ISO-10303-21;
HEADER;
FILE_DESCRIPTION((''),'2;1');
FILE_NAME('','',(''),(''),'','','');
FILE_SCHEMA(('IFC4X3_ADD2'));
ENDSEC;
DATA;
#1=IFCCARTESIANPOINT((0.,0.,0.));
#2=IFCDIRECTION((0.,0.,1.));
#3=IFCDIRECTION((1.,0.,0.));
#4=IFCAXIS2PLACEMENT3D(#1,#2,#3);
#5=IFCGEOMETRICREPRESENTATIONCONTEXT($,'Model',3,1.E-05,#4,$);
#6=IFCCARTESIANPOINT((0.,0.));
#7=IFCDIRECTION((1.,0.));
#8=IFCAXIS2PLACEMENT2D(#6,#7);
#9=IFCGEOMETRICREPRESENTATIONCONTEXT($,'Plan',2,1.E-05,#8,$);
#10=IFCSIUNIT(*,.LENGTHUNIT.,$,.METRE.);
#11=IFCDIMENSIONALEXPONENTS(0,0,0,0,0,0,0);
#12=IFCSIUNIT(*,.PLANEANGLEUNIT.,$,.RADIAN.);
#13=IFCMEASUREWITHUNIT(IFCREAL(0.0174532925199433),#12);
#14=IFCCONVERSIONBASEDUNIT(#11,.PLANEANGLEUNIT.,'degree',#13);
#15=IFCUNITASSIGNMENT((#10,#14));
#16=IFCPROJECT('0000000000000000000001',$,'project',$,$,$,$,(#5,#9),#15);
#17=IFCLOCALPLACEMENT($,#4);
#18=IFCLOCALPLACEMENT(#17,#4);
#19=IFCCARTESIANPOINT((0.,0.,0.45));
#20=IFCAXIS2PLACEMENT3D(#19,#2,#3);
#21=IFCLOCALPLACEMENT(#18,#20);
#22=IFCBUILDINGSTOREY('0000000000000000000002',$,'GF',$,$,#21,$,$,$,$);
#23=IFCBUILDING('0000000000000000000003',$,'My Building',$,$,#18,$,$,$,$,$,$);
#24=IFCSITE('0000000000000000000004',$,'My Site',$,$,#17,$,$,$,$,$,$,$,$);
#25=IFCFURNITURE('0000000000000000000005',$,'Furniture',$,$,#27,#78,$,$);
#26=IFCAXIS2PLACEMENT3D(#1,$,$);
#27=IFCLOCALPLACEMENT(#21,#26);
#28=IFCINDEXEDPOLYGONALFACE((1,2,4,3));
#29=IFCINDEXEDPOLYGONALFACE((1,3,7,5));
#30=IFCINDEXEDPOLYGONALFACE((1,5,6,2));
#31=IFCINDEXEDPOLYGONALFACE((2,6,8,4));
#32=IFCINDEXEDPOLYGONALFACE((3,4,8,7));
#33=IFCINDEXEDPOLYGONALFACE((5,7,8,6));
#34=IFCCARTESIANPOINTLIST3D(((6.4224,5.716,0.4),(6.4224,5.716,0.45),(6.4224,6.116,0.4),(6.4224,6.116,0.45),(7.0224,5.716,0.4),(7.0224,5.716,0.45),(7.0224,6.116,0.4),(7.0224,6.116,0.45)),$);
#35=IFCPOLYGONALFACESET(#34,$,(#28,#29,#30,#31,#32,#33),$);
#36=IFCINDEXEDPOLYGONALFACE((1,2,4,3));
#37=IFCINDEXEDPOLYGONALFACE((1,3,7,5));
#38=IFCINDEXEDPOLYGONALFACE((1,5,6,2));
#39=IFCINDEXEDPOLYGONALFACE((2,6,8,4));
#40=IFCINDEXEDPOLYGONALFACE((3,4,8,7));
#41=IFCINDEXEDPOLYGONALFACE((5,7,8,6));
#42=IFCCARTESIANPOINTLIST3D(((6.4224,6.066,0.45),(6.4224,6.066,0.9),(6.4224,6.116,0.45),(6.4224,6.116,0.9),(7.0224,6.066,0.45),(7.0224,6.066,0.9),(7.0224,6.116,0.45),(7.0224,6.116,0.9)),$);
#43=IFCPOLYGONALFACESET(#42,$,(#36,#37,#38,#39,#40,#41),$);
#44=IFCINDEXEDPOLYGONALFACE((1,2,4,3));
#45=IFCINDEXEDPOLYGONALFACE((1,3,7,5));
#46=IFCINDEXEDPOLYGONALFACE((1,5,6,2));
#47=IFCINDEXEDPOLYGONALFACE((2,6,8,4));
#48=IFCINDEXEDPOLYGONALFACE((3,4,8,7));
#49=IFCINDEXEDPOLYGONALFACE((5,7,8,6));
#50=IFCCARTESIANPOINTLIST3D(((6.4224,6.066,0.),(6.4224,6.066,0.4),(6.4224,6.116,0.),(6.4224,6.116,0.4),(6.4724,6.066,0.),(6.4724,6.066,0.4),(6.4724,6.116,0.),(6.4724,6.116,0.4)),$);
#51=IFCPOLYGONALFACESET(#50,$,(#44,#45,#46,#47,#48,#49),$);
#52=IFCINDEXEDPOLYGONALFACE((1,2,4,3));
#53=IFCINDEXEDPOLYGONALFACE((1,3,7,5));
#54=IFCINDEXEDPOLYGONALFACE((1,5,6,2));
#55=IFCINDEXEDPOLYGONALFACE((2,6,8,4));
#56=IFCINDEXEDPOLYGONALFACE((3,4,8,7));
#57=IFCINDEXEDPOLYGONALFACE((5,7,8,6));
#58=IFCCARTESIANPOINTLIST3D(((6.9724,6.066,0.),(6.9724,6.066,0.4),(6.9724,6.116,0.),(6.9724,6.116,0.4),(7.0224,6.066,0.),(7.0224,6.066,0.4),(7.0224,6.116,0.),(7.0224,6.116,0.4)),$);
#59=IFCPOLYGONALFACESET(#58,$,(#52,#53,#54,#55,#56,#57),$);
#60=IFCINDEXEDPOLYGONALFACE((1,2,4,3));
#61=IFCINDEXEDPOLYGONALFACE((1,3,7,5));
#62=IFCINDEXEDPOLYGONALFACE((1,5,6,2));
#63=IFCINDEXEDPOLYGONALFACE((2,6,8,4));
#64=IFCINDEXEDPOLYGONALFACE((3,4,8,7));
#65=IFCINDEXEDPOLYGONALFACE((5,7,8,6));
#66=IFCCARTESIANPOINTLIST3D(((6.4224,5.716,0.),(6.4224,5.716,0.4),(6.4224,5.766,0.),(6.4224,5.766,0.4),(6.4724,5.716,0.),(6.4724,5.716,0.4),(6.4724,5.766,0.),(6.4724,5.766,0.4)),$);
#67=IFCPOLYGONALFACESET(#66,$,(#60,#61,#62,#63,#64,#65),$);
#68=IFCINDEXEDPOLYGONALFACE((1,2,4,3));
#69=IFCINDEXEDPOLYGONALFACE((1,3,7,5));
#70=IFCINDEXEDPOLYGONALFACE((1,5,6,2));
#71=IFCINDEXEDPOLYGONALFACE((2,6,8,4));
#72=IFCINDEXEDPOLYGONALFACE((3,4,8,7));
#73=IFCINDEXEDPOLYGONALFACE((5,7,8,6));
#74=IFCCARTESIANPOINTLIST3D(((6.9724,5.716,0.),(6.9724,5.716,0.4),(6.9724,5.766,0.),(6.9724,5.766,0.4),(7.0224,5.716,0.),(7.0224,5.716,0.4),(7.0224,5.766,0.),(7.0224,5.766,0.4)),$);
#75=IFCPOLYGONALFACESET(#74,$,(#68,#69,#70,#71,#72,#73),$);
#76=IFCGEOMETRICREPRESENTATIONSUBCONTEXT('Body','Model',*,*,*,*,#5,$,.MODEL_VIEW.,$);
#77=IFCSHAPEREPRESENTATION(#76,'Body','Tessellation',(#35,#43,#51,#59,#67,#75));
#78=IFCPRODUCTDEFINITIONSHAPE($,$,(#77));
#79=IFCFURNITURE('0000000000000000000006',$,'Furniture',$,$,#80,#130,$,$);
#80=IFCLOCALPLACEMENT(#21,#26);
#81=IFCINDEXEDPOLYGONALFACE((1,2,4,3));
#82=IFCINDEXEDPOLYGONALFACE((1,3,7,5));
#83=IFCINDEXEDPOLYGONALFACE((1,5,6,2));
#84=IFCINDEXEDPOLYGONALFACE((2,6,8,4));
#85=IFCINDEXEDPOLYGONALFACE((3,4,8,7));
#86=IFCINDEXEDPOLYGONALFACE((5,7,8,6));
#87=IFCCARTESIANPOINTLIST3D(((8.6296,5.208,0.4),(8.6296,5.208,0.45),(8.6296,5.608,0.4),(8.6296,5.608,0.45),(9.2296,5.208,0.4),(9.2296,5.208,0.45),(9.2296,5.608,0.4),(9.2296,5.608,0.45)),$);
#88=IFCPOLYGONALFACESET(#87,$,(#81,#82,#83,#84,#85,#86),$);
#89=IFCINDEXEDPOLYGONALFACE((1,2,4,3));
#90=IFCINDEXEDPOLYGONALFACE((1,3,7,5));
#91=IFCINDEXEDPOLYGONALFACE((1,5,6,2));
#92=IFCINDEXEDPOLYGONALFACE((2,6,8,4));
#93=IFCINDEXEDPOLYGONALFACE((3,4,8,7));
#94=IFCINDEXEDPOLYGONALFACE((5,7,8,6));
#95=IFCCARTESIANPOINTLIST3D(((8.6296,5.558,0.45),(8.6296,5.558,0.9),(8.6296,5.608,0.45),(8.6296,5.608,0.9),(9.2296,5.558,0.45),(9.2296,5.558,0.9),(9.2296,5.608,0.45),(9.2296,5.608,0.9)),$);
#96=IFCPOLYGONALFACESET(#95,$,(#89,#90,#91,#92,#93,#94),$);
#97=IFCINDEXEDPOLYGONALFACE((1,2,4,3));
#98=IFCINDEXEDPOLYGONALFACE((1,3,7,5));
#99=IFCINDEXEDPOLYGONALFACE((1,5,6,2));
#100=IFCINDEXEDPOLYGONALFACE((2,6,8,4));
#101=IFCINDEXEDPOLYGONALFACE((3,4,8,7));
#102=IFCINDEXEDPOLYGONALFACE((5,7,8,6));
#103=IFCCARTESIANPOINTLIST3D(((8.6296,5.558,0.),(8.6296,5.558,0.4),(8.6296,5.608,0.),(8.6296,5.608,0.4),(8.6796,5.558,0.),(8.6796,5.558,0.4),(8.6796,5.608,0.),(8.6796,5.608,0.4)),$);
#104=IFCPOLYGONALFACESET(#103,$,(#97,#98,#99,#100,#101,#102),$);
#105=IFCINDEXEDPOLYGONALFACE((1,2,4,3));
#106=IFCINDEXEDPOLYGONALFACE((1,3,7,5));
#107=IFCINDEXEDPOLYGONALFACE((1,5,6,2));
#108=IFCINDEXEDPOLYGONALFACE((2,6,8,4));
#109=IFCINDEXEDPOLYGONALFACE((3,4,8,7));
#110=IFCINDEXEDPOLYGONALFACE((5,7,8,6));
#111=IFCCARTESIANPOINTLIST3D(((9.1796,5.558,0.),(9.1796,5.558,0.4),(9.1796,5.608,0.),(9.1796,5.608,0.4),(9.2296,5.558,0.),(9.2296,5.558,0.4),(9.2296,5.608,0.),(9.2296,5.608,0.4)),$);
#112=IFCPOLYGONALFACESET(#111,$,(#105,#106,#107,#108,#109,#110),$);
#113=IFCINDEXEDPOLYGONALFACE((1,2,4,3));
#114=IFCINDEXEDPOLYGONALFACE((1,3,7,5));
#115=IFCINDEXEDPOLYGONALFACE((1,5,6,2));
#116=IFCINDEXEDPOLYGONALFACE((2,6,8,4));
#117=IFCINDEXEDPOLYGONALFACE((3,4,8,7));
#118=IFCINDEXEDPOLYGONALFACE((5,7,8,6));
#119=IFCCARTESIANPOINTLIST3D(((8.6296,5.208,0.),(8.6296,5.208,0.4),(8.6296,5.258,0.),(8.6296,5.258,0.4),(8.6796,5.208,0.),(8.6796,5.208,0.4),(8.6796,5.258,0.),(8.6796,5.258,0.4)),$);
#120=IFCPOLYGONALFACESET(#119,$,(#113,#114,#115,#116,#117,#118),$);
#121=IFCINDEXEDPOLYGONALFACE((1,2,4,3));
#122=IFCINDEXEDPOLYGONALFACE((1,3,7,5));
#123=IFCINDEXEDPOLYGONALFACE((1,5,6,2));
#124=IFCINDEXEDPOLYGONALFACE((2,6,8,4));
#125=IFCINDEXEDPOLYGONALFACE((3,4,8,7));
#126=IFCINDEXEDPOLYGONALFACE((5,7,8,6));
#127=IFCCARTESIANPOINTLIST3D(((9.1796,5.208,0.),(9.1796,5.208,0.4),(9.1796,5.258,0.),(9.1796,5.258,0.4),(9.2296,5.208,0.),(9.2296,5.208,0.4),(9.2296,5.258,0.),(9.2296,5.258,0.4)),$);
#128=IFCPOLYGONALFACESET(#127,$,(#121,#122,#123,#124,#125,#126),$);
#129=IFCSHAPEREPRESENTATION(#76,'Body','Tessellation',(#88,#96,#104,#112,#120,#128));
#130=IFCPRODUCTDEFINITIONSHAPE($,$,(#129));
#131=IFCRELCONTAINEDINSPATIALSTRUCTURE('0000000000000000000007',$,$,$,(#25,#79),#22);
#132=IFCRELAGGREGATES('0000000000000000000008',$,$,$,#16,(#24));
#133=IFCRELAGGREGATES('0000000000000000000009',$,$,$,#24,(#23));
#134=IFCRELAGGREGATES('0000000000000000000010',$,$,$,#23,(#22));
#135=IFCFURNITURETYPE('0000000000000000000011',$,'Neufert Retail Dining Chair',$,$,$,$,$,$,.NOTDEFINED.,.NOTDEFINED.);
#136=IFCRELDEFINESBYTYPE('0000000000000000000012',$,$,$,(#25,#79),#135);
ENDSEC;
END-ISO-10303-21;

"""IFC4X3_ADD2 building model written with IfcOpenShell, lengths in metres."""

from ifc_helpers import new_model, entity, si_unit, converted_unit, frame, origin_with_axes, origin_2d_with_axis, place, context, subcontext, project, spatial, line, indexed_curve, outline, extrude, shape, source, transform, mapped, type_object, type_shapes, element, save


model = new_model("IFC4X3_ADD2")

# Units and contexts
model_context = context("Model", 3, precision=1e-05, world=origin_with_axes())
plan_context = context("Plan", 2, precision=1e-05, world=origin_2d_with_axis())
body_context_1 = subcontext(model_context, "Body", "Model", "MODEL_VIEW")
body_context_2 = subcontext(plan_context, "Body", "Plan", "PLAN_VIEW")
ifc_project = project(units=[si_unit("LENGTHUNIT", "METRE"), converted_unit("PLANEANGLEUNIT", "degree", entity("IfcReal", 0.0174532925199433), si_unit("PLANEANGLEUNIT", "RADIAN"), dimensions=[0, 0, 0, 0, 0, 0, 0])], contexts=[model_context, plan_context])

# Site, building, storey
site_placement = place(None, origin_with_axes())
site = spatial("IfcSite", under=ifc_project, at=site_placement, Name="My Site")
building_placement = place(site_placement, origin_with_axes())
building = spatial("IfcBuilding", under=site, at=building_placement, Name="My Building")
storey_placement = place(building_placement, frame((0.0, 0.0, 0.45), z_axis=(0.0, 0.0, 1.0), x_axis=(1.0, 0.0, 0.0)))
storey = spatial("IfcBuildingStorey", under=building, at=storey_placement, Name="GF")

# Furniture
furniture_type = type_object("IfcFurnitureType", Name="Neufert Retail Dining Chair", AssemblyPlace="NOTDEFINED", PredefinedType="NOTDEFINED")
shared_shape_1 = source(origin_with_axes(), body_context_1, "Body", "SweptSolid", [
    extrude(outline(indexed_curve([(-0.3, 0.0), (0.3, 0.0), (0.3, -0.4), (-0.3, -0.4)], segments=[line(1, 2, 3, 4, 1)])), frame((0.0, 0.0, 0.45), z_axis=(0.0, 0.0, 1.0), x_axis=(1.0, 0.0, 0.0)), (0.0, 0.0, -1.0), 0.05),
    extrude(outline(indexed_curve([(-0.3, 0.0), (0.3, 0.0), (0.3, -0.05), (-0.3, -0.05)], segments=[line(1, 2, 3, 4, 1)])), frame((0.0, 0.0, 0.9), z_axis=(0.0, 0.0, 1.0), x_axis=(1.0, 0.0, 0.0)), (0.0, 0.0, -1.0), 0.45),
    extrude(outline(indexed_curve([(-0.3, 0.0), (-0.25, 0.0), (-0.25, -0.05), (-0.3, -0.05)], segments=[line(1, 2, 3, 4, 1)])), origin_with_axes(), (0.0, 0.0, 1.0), 0.4),
    extrude(outline(indexed_curve([(0.3, 0.0), (0.25, 0.0), (0.25, -0.05), (0.3, -0.05)], segments=[line(1, 2, 3, 4, 1)])), origin_with_axes(), (0.0, 0.0, 1.0), 0.4),
    extrude(outline(indexed_curve([(-0.3, -0.4), (-0.25, -0.4), (-0.25, -0.35), (-0.3, -0.35)], segments=[line(1, 2, 3, 4, 1)])), origin_with_axes(), (0.0, 0.0, 1.0), 0.4),
    extrude(outline(indexed_curve([(0.3, -0.4), (0.25, -0.4), (0.25, -0.35), (0.3, -0.35)], segments=[line(1, 2, 3, 4, 1)])), origin_with_axes(), (0.0, 0.0, 1.0), 0.4),
])
shared_shape_2 = source(origin_with_axes(), body_context_2, "Body", "Curve2D", [
    entity("IfcIndexedPolyCurve", entity("IfcCartesianPointList2D", [[-0.3, -0.4], [0.3, -0.4]])),
    entity("IfcIndexedPolyCurve", entity("IfcCartesianPointList2D", [[-0.3, -0.4], [-0.3, -0.3], [-0.2121, -0.0879], [0.0, 0.0], [0.2121, -0.0879], [0.3, -0.3], [0.3, -0.4]]), [entity("IfcLineIndex", [1, 2]), entity("IfcArcIndex", [2, 3, 4]), entity("IfcArcIndex", [4, 5, 6]), entity("IfcLineIndex", [6, 7])]),
    entity("IfcIndexedPolyCurve", entity("IfcCartesianPointList2D", [[-0.26, -0.4], [-0.26, -0.3], [-0.1838, -0.1162], [0.0, -0.04], [0.1838, -0.1162], [0.26, -0.3], [0.26, -0.4]]), [entity("IfcLineIndex", [1, 2]), entity("IfcArcIndex", [2, 3, 4]), entity("IfcArcIndex", [4, 5, 6]), entity("IfcLineIndex", [6, 7])]),
])
type_shapes(furniture_type, [shared_shape_1, shared_shape_2])
for number, where, z_axis, x_axis, name in (
    (1, (6.7224, 6.116, 0.0), (0.0, 0.0, 1.0), (1.0, -0.000001, 0.0), "Furniture"),
    (2, (8.9296, 5.608, 0.0), (0.0, 0.0, 1.0), (1.0, -0.000001, 0.0), "Furniture"),
):
    element("IfcFurniture", number, at=place(storey_placement, frame(where, z_axis=z_axis, x_axis=x_axis)), inside=storey, type_object=furniture_type, Name=name, shapes=[
        shape(body_context_1, "Body", "MappedRepresentation", [mapped(shared_shape_1, transform((0.0, 0.0, 0.0), x_axis=(1.0, 0.0, 0.0), y_axis=(0.0, 1.0, 0.0), z_axis=(0.0, 0.0, 1.0), scale=1.0))]),
        shape(body_context_2, "Body", "MappedRepresentation", [mapped(shared_shape_2, transform((0.0, 0.0, 0.0), x_axis=(1.0, 0.0, 0.0), y_axis=(0.0, 1.0, 0.0), z_axis=(0.0, 0.0, 1.0), scale=1.0))]),
    ])

save(model, "model.ifc")
